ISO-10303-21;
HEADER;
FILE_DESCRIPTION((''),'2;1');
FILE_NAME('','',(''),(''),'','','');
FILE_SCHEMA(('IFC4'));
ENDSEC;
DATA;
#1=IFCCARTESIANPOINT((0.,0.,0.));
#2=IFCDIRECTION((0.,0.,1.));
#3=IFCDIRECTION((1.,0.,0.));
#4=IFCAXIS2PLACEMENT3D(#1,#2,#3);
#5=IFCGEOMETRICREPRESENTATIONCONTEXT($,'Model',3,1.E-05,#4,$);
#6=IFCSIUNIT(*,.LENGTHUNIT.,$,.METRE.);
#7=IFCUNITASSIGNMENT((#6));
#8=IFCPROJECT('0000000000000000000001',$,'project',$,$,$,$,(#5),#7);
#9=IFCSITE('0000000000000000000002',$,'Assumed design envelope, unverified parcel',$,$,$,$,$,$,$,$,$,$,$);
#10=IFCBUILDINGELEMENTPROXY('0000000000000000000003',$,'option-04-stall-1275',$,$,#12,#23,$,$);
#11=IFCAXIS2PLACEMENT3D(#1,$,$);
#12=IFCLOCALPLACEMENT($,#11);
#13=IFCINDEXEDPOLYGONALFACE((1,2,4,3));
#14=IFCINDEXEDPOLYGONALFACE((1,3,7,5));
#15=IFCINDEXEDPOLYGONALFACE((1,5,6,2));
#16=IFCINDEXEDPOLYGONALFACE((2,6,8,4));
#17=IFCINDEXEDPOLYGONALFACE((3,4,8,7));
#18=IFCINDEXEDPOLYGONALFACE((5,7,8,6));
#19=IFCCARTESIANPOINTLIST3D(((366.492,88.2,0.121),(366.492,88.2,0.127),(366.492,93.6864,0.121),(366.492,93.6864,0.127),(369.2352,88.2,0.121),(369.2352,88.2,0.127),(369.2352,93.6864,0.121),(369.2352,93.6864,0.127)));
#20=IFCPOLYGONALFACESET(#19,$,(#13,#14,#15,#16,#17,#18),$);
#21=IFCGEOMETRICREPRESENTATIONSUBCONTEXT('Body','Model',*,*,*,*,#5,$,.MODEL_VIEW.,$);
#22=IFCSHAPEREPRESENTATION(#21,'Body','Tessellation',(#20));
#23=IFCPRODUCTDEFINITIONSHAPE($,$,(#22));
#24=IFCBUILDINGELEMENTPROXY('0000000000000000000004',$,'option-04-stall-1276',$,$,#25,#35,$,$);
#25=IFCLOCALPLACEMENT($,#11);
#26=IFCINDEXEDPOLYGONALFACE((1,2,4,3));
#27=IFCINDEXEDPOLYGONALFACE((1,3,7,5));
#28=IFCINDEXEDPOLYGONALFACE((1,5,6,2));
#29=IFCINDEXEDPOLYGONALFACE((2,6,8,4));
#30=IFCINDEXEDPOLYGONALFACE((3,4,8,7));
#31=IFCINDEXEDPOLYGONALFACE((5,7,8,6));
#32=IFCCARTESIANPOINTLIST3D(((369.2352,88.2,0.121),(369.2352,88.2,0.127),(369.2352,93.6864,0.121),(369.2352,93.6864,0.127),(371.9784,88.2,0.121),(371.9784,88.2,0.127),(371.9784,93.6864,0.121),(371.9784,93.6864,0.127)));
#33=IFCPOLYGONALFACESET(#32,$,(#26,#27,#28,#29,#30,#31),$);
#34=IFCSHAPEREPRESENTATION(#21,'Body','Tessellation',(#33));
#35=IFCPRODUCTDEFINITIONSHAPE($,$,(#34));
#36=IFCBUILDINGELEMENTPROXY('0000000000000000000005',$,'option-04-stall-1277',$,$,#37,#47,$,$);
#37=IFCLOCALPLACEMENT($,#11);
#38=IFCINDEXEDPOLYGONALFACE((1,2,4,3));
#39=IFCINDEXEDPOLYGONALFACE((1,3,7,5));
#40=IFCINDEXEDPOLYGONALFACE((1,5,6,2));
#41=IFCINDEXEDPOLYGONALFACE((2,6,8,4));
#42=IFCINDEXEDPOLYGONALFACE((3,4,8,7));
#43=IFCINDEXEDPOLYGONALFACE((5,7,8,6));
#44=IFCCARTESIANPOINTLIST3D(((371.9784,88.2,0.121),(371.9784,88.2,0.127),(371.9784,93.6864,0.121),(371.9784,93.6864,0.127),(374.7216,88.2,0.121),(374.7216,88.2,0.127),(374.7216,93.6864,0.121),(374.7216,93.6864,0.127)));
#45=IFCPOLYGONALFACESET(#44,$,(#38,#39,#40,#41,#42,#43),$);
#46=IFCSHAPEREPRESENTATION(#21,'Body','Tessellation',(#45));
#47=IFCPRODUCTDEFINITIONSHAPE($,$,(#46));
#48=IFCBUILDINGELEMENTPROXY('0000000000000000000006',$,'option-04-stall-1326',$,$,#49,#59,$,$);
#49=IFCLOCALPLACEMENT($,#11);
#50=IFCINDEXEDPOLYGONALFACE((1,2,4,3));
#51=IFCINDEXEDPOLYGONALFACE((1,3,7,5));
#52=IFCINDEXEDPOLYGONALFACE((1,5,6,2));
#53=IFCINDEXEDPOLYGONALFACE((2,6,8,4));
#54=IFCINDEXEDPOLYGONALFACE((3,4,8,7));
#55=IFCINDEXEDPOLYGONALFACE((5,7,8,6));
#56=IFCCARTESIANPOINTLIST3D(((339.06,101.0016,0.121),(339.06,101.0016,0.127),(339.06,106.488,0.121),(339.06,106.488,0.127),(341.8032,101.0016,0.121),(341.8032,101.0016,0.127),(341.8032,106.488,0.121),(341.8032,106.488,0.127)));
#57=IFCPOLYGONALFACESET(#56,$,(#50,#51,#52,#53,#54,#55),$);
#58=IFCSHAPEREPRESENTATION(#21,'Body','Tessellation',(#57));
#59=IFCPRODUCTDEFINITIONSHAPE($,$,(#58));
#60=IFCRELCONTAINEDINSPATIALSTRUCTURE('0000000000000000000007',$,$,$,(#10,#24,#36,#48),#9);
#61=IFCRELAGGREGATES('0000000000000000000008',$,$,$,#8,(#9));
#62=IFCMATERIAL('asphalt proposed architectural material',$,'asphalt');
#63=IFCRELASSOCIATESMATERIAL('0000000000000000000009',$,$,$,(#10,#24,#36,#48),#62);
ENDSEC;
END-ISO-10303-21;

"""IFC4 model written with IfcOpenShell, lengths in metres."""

from ifc_helpers import new_model, si_unit, frame, origin_with_axes, place, context, subcontext, project, spatial, rectangle, extrude, material, element, save


model = new_model("IFC4")

# Units and contexts
model_context = context("Model", 3, precision=1e-05, world=origin_with_axes())
body_context = subcontext(model_context, "Body", "Model", "MODEL_VIEW")
ifc_project = project(units=[si_unit("LENGTHUNIT", "METRE")], contexts=[model_context])

# Site
site = spatial("IfcSite", under=ifc_project, Name="Assumed design envelope, unverified parcel")

# Building element proxies
ifc_material_1 = material(Name="asphalt proposed architectural material", Category="asphalt")
for number, where, z_axis, x_axis, name in (
    (1, (367.8636, 90.9432, 0.121), (0.0, 0.0, 1.0), (1.0, 0.0, 0.0), "option-04-stall-1275"),
    (2, (370.6068, 90.9432, 0.121), (0.0, 0.0, 1.0), (1.0, 0.0, 0.0), "option-04-stall-1276"),
    (3, (373.35, 90.9432, 0.121), (0.0, 0.0, 1.0), (1.0, 0.0, 0.0), "option-04-stall-1277"),
    (4, (340.4316, 103.7448, 0.121), (0.0, 0.0, 1.0), (1.0, 0.0, 0.0), "option-04-stall-1326"),
):
    element("IfcBuildingElementProxy", number, at=place(None, frame(where, z_axis=z_axis, x_axis=x_axis)), inside=site, material=ifc_material_1, Name=name, context=body_context, shape_type="SweptSolid", body=[
        extrude(rectangle(XDim=2.7432, YDim=5.4864), origin_with_axes(), (0.0, 0.0, 1.0), 0.006),
    ])

save(model, "model.ifc")
